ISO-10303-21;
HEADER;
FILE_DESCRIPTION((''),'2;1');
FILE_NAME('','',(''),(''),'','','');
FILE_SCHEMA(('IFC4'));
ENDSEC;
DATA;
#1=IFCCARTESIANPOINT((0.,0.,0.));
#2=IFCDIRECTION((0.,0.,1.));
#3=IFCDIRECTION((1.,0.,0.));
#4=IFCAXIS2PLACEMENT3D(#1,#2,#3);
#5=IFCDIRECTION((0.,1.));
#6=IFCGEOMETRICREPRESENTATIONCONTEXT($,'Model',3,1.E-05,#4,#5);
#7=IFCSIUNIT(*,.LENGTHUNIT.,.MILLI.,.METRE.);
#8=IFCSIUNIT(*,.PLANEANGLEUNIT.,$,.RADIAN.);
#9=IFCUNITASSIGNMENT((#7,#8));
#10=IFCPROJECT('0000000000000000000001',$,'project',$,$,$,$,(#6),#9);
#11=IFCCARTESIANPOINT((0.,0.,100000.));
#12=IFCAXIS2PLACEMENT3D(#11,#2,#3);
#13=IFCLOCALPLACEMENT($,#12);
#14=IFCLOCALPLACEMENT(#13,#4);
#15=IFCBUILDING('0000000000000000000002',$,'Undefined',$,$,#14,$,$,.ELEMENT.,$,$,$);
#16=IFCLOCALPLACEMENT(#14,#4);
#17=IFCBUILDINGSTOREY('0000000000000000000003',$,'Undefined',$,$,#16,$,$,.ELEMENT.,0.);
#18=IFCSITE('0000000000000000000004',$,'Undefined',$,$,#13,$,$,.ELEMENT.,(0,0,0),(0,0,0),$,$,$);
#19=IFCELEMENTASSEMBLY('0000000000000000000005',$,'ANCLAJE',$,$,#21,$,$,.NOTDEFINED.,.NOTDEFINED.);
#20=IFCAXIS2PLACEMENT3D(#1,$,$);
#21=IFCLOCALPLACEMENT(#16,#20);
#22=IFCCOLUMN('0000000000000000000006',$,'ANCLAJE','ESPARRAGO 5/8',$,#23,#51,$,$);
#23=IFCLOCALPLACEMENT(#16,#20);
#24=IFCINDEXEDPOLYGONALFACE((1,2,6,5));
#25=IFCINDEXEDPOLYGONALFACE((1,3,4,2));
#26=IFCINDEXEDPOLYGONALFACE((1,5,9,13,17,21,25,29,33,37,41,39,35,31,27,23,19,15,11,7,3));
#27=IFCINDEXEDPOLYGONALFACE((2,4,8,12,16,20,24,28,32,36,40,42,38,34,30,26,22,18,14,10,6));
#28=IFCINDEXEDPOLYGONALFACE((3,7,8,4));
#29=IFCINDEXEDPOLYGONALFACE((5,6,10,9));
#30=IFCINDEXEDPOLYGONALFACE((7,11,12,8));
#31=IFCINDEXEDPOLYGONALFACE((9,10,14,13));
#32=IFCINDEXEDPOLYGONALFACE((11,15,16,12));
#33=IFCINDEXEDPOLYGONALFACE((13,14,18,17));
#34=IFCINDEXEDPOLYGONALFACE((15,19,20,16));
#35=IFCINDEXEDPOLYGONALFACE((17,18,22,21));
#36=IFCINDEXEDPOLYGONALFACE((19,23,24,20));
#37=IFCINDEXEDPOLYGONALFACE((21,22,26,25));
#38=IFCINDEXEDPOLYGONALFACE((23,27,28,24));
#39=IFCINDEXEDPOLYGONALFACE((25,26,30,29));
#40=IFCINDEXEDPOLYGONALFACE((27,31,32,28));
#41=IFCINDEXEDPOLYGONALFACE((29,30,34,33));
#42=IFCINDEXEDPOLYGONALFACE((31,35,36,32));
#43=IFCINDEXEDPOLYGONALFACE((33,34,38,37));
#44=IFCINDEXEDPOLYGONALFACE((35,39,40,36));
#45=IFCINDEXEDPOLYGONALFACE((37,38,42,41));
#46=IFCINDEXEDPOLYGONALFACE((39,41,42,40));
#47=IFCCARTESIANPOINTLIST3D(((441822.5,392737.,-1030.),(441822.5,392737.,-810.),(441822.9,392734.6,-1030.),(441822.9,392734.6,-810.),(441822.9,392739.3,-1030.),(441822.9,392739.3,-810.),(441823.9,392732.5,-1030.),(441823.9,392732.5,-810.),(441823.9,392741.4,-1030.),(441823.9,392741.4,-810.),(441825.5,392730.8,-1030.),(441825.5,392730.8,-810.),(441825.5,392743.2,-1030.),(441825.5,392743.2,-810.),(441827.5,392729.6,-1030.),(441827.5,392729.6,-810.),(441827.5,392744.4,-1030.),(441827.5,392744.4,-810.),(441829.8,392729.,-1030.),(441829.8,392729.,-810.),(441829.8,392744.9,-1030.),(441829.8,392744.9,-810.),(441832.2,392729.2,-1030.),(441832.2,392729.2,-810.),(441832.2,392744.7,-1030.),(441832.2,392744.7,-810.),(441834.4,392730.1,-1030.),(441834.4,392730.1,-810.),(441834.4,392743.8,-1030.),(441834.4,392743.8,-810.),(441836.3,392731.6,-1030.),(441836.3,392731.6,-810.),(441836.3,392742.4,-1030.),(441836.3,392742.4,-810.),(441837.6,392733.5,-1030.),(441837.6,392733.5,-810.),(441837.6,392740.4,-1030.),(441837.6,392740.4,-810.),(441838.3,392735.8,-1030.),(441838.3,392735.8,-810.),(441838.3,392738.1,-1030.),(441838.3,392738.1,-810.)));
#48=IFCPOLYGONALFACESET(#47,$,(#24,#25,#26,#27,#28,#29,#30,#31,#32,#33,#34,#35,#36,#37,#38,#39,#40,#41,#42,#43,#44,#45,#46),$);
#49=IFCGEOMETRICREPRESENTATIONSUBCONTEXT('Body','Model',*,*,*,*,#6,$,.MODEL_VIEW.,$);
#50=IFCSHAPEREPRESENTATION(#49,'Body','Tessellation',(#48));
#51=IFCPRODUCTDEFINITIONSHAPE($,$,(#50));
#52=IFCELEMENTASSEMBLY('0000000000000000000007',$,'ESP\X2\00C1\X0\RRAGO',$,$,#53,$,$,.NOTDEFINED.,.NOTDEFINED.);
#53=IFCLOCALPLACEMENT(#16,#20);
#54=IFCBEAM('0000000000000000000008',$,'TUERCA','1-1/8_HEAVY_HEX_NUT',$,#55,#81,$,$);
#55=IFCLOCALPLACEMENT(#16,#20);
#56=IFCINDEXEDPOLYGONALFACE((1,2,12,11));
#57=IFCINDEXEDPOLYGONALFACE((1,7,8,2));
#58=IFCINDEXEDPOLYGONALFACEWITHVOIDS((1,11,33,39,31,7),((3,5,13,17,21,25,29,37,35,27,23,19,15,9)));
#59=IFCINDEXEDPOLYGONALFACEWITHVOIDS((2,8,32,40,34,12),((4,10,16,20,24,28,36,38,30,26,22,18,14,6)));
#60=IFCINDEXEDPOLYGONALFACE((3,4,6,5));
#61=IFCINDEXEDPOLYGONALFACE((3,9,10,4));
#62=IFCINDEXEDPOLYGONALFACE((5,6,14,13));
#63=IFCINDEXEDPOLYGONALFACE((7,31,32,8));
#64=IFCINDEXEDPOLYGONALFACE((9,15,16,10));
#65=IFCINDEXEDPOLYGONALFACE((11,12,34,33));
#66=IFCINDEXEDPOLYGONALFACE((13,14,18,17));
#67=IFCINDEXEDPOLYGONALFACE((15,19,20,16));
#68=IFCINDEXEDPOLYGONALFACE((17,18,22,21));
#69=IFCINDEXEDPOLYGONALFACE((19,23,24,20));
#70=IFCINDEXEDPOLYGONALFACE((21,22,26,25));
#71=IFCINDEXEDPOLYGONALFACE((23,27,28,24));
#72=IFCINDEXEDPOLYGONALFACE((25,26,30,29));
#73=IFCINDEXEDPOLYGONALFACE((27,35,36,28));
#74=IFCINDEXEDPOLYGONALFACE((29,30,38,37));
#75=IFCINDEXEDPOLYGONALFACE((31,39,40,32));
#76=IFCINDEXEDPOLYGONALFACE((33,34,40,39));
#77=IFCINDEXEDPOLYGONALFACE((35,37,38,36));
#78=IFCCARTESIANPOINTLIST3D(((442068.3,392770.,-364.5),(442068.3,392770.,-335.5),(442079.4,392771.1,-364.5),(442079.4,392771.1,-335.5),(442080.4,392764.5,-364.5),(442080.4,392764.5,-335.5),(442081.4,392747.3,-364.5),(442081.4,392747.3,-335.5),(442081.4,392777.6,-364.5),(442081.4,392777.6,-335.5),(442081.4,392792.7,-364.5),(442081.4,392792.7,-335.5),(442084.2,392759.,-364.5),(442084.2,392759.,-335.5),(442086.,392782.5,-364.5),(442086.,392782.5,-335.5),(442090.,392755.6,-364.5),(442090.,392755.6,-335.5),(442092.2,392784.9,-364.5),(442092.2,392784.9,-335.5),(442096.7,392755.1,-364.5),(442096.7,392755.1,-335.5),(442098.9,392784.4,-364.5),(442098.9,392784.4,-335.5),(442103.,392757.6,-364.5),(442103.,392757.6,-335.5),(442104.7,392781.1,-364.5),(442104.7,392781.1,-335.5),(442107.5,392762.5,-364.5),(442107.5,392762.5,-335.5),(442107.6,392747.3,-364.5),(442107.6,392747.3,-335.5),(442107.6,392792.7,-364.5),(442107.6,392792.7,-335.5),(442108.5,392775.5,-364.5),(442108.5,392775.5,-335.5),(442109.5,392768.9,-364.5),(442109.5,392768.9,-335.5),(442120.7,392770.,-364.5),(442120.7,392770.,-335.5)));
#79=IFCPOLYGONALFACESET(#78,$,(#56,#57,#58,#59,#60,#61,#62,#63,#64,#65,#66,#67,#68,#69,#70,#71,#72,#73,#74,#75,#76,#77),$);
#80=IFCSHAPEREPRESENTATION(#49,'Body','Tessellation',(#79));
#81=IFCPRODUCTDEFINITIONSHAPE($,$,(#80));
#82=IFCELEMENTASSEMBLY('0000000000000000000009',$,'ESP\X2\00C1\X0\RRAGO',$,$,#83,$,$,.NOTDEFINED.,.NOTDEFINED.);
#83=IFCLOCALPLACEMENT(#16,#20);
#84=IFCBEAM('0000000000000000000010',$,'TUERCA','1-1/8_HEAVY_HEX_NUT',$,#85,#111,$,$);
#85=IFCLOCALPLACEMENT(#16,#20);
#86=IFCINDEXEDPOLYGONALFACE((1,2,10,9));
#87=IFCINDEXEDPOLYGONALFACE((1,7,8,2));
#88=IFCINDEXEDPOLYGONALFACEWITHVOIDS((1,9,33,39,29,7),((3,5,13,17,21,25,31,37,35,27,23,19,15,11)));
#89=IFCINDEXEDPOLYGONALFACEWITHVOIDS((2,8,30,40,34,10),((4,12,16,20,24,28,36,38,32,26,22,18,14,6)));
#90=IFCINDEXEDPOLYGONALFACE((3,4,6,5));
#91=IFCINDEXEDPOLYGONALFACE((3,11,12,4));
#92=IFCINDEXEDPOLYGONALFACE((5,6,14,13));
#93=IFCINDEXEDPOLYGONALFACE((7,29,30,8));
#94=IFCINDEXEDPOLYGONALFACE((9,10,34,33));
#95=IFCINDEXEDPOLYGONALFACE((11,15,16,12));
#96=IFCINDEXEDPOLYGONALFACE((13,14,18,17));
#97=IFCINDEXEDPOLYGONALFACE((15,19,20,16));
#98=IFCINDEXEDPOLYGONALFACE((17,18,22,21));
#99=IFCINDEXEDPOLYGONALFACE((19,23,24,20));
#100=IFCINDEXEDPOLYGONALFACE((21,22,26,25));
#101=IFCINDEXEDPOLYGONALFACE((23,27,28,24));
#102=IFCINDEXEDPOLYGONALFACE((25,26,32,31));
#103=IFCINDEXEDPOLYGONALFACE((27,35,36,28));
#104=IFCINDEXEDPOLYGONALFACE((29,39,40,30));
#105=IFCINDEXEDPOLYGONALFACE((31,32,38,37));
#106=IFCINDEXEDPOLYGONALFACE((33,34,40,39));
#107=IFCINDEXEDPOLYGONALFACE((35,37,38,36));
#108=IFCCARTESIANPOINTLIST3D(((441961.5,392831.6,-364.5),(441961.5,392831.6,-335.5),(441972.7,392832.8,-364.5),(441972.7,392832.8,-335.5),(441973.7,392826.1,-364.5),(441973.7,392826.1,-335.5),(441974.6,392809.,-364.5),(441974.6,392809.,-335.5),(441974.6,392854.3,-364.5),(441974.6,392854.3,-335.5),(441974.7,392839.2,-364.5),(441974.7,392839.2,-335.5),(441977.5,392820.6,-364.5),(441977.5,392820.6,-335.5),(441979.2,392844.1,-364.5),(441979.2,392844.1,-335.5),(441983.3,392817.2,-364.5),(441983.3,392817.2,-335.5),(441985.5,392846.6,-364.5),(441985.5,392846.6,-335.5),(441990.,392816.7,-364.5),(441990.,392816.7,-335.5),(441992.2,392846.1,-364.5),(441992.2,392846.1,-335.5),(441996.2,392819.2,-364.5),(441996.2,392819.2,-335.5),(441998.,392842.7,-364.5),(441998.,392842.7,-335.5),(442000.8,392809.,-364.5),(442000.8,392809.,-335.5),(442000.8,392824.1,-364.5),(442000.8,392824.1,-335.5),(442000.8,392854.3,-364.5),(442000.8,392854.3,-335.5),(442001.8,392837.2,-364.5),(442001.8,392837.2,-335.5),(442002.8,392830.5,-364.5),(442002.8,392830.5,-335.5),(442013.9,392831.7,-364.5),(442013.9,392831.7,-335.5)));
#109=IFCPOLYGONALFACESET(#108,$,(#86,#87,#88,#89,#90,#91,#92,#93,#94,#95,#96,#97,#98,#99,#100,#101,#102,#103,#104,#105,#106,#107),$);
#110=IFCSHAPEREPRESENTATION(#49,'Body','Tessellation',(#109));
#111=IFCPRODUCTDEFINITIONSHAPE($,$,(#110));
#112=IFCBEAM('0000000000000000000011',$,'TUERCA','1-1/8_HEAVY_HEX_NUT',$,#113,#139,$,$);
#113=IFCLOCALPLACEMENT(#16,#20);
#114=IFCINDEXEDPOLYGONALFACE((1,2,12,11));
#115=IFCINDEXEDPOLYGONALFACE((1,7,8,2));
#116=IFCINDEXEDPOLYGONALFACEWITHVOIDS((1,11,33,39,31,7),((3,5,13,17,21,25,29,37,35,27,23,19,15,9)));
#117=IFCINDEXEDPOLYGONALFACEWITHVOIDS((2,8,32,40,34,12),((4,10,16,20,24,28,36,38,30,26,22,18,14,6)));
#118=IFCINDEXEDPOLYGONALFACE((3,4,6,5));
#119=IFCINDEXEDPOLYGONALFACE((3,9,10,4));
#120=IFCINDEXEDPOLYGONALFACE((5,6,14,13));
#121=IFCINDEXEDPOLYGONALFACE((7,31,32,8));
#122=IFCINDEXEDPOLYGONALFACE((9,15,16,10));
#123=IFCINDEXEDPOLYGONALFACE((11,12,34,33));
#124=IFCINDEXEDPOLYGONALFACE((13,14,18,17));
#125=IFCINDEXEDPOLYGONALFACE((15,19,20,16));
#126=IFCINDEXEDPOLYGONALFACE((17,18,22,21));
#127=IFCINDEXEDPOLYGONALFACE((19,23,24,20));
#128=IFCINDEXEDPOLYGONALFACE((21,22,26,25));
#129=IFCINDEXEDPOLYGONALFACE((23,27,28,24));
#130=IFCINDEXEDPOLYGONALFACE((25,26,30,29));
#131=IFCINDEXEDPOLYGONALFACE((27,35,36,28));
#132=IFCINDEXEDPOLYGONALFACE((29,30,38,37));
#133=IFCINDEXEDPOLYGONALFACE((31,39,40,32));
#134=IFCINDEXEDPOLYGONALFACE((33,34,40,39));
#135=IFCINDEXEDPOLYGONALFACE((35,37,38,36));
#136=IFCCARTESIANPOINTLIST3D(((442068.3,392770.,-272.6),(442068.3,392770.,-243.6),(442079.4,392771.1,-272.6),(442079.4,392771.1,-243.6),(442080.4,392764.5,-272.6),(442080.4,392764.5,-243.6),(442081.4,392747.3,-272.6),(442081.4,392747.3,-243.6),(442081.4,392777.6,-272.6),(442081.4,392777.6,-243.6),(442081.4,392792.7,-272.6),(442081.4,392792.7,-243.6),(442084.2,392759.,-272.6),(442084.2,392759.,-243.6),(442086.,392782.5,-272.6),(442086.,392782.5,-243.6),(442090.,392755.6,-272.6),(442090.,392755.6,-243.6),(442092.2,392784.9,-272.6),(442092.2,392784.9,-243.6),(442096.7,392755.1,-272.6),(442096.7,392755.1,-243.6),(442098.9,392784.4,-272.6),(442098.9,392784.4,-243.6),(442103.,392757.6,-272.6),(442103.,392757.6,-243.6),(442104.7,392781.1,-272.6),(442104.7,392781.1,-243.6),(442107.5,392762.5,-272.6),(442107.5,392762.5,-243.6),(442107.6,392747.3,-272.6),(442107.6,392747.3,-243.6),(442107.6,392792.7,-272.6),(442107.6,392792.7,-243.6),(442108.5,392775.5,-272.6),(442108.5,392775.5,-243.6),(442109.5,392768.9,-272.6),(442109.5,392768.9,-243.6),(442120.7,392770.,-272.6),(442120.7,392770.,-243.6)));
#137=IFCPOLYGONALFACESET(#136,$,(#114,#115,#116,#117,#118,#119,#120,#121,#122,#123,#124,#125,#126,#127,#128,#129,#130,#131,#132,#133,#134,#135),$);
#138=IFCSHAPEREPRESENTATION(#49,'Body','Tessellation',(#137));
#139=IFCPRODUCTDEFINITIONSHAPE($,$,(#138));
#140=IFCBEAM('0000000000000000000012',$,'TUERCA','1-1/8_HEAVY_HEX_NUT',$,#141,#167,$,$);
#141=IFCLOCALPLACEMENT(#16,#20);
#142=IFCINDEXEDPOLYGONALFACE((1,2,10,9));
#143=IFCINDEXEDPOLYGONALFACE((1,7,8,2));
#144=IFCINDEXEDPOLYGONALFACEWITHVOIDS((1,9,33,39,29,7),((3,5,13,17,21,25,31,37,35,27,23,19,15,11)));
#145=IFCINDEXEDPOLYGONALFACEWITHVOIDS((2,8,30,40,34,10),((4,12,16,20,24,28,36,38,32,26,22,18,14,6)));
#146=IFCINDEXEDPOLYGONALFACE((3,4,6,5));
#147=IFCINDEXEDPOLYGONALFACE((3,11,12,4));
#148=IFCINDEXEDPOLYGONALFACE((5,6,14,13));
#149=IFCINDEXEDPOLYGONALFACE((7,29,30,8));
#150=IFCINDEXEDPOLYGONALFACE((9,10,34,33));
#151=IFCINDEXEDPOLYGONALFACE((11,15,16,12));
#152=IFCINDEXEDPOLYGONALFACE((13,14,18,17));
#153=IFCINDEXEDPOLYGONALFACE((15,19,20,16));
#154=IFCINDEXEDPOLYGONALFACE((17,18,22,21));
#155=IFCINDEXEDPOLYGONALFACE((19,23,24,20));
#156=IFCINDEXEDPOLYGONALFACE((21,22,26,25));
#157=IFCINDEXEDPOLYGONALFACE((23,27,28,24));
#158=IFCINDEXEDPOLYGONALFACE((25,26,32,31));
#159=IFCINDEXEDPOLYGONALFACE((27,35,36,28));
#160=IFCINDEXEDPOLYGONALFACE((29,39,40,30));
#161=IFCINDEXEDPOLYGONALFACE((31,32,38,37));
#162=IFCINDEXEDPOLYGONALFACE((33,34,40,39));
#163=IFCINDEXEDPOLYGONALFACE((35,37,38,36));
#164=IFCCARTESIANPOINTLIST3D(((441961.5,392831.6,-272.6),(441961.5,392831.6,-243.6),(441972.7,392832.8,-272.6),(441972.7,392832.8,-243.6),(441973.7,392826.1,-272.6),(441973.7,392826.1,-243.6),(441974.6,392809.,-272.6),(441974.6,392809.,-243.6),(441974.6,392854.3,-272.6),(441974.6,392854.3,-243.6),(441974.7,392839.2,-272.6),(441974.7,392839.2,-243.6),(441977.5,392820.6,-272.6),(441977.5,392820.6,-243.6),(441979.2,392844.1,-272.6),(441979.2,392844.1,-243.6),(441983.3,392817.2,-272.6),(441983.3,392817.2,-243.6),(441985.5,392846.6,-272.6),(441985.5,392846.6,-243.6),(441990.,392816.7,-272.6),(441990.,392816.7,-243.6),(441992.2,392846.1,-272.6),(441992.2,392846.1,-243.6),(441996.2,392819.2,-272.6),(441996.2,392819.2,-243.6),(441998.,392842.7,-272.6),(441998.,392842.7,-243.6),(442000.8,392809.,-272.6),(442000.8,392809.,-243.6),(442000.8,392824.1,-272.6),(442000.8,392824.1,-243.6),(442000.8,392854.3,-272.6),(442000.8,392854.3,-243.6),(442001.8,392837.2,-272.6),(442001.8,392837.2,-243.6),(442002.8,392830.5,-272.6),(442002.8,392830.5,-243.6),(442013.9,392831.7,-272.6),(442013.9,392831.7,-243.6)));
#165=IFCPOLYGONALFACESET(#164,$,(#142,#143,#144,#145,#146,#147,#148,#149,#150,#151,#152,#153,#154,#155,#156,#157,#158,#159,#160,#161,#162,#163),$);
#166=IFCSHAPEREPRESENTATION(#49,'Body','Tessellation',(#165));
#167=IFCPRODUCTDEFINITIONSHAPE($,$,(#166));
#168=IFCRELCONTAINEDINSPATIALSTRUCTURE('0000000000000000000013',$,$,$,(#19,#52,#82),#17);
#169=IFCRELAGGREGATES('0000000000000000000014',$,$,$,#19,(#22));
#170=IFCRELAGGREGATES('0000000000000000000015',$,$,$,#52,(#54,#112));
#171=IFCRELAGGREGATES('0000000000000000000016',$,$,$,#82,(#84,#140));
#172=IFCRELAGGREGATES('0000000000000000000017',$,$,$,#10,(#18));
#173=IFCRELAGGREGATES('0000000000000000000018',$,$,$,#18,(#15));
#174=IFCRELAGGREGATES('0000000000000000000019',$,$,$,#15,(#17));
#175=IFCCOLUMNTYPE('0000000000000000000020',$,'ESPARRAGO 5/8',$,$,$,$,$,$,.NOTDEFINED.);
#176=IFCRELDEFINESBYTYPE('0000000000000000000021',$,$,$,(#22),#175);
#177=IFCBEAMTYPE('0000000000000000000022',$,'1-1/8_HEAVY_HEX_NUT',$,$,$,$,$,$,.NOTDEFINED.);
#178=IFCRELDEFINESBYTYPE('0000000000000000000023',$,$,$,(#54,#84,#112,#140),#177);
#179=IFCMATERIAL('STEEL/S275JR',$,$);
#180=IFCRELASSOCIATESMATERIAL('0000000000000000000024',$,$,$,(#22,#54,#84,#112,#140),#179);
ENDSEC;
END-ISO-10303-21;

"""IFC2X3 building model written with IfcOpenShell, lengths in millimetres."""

from ifc_helpers import new_model, si_unit, direction, frame, origin_with_axes, origin_2d_with_axis, place, context, subcontext, project, spatial, polyline, circle, outline, extrude, material, type_object, element, aggregate, save


model = new_model("IFC2X3")

# Units and contexts
model_context = context("Model", 3, precision=1e-05, world=origin_with_axes(), true_north=direction((0.0, 1.0)))
body_context = subcontext(model_context, "Body", "Model", "MODEL_VIEW")
ifc_project = project(units=[si_unit("LENGTHUNIT", "METRE", prefix="MILLI"), si_unit("PLANEANGLEUNIT", "RADIAN")], contexts=[model_context])

# Site, building, storey
site_placement = place(None, frame((0.0, 0.0, 100000.0), z_axis=(0.0, 0.0, 1.0), x_axis=(1.0, 0.0, 0.0)))
site = spatial("IfcSite", under=ifc_project, at=site_placement, Name="Undefined", CompositionType="ELEMENT", RefLatitude=(0, 0, 0), RefLongitude=(0, 0, 0))
building_placement = place(site_placement, origin_with_axes())
building = spatial("IfcBuilding", under=site, at=building_placement, Name="Undefined", CompositionType="ELEMENT")
storey_placement = place(building_placement, origin_with_axes())
storey = spatial("IfcBuildingStorey", under=building, at=storey_placement, Name="Undefined", CompositionType="ELEMENT", Elevation=0.0)

# Element assembly
ifc_material_1 = material(Name="STEEL/S275JR")
assembly_1_placement = place(storey_placement, origin_with_axes())
assembly_1 = element("IfcElementAssembly", 1, at=assembly_1_placement, inside=storey, Name="ANCLAJE", AssemblyPlace="NOTDEFINED", PredefinedType="NOTDEFINED")

# Column
column_type_1 = type_object("IfcColumnType", Name="ESPARRAGO 5/8", PredefinedType="NOTDEFINED")
column_1_placement = place(assembly_1_placement, frame((441830.4, 392737.0, -810.0), z_axis=(0.0, 0.0, -1.0), x_axis=(0.866025, 0.5, 0.0)))
column_1 = element("IfcColumn", 2, at=column_1_placement, type_object=column_type_1, material=ifc_material_1, Name="ANCLAJE", Description="ESPARRAGO 5/8", context=body_context, shape_type="SweptSolid", body=[
    extrude(circle(Radius=7.9, at=origin_2d_with_axis()), frame((0.0, 0.0, 220.0), z_axis=(0.0, 0.0, -1.0), x_axis=(0.0, 1.0, 0.0)), (0.0, 0.0, 1.0), 220.0),
])
aggregate(assembly_1, [column_1])

# Element assemblies, beams
assembly_2_placement = place(storey_placement, origin_with_axes())
assembly_2 = element("IfcElementAssembly", 3, at=assembly_2_placement, inside=storey, Name="ESPÁRRAGO", AssemblyPlace="NOTDEFINED", PredefinedType="NOTDEFINED")
beam_type_1 = type_object("IfcBeamType", Name="1-1/8_HEAVY_HEX_NUT", PredefinedType="NOTDEFINED")
beam_1_placement = place(assembly_2_placement, frame((442094.5, 392770.0, -335.5), z_axis=(0.866025, -0.5, 0.0), x_axis=(0.0, 0.0, -1.0)))
beam_1 = element("IfcBeam", 4, at=beam_1_placement, type_object=beam_type_1, material=ifc_material_1, Name="TUERCA", Description="1-1/8_HEAVY_HEX_NUT", context=body_context, shape_type="SweptSolid", body=[
    extrude(outline(polyline([(-13.1, -22.7), (-26.2, 0.0), (-13.1, 22.7), (13.1, 22.7), (26.2, 0.0), (13.1, -22.7), (-13.1, -22.7)]), holes=[polyline([(6.5, 13.6), (0.0, 15.1), (-6.5, 13.6), (-11.8, 9.4), (-14.7, 3.4), (-14.7, -3.4), (-11.8, -9.4), (-6.5, -13.6), (0.0, -15.1), (6.5, -13.6), (11.8, -9.4), (14.7, -3.4), (14.7, 3.4), (11.8, 9.4), (6.5, 13.6)])]), frame((29.0, 0.0, 0.0), z_axis=(-1.0, 0.0, 0.0), x_axis=(0.0, -1.0, 0.0)), (0.0, 0.0, 1.0), 29.0),
])
assembly_3_placement = place(storey_placement, origin_with_axes())
assembly_3 = element("IfcElementAssembly", 5, at=assembly_3_placement, inside=storey, Name="ESPÁRRAGO", AssemblyPlace="NOTDEFINED", PredefinedType="NOTDEFINED")
beam_2_placement = place(assembly_3_placement, frame((441987.7, 392831.7, -335.5), z_axis=(0.866025, -0.5, 0.0), x_axis=(0.0, 0.0, -1.0)))
beam_2 = element("IfcBeam", 6, at=beam_2_placement, type_object=beam_type_1, material=ifc_material_1, Name="TUERCA", Description="1-1/8_HEAVY_HEX_NUT", context=body_context, shape_type="SweptSolid", body=[
    extrude(outline(polyline([(-13.1, -22.7), (-26.2, 0.0), (-13.1, 22.7), (13.1, 22.7), (26.2, 0.0), (13.1, -22.7), (-13.1, -22.7)]), holes=[polyline([(6.5, 13.6), (0.0, 15.1), (-6.5, 13.6), (-11.8, 9.4), (-14.7, 3.4), (-14.7, -3.4), (-11.8, -9.4), (-6.5, -13.6), (0.0, -15.1), (6.5, -13.6), (11.8, -9.4), (14.7, -3.4), (14.7, 3.4), (11.8, 9.4), (6.5, 13.6)])]), frame((29.0, 0.0, 0.0), z_axis=(-1.0, 0.0, 0.0), x_axis=(0.0, -1.0, 0.0)), (0.0, 0.0, 1.0), 29.0),
])

# Beams
beam_3_placement = place(assembly_2_placement, frame((442094.5, 392770.0, -243.6), z_axis=(0.866025, -0.5, 0.0), x_axis=(0.0, 0.0, -1.0)))
beam_3 = element("IfcBeam", 7, at=beam_3_placement, type_object=beam_type_1, material=ifc_material_1, Name="TUERCA", Description="1-1/8_HEAVY_HEX_NUT", context=body_context, shape_type="SweptSolid", body=[
    extrude(outline(polyline([(-13.1, -22.7), (-26.2, 0.0), (-13.1, 22.7), (13.1, 22.7), (26.2, 0.0), (13.1, -22.7), (-13.1, -22.7)]), holes=[polyline([(6.5, 13.6), (0.0, 15.1), (-6.5, 13.6), (-11.8, 9.4), (-14.7, 3.4), (-14.7, -3.4), (-11.8, -9.4), (-6.5, -13.6), (0.0, -15.1), (6.5, -13.6), (11.8, -9.4), (14.7, -3.4), (14.7, 3.4), (11.8, 9.4), (6.5, 13.6)])]), frame((29.0, 0.0, 0.0), z_axis=(-1.0, 0.0, 0.0), x_axis=(0.0, -1.0, 0.0)), (0.0, 0.0, 1.0), 29.0),
])
beam_4_placement = place(assembly_3_placement, frame((441987.7, 392831.7, -243.6), z_axis=(0.866025, -0.5, 0.0), x_axis=(0.0, 0.0, -1.0)))
beam_4 = element("IfcBeam", 8, at=beam_4_placement, type_object=beam_type_1, material=ifc_material_1, Name="TUERCA", Description="1-1/8_HEAVY_HEX_NUT", context=body_context, shape_type="SweptSolid", body=[
    extrude(outline(polyline([(-13.1, -22.7), (-26.2, 0.0), (-13.1, 22.7), (13.1, 22.7), (26.2, 0.0), (13.1, -22.7), (-13.1, -22.7)]), holes=[polyline([(6.5, 13.6), (0.0, 15.1), (-6.5, 13.6), (-11.8, 9.4), (-14.7, 3.4), (-14.7, -3.4), (-11.8, -9.4), (-6.5, -13.6), (0.0, -15.1), (6.5, -13.6), (11.8, -9.4), (14.7, -3.4), (14.7, 3.4), (11.8, 9.4), (6.5, 13.6)])]), frame((29.0, 0.0, 0.0), z_axis=(-1.0, 0.0, 0.0), x_axis=(0.0, -1.0, 0.0)), (0.0, 0.0, 1.0), 29.0),
])

aggregate(assembly_2, [beam_1, beam_3])
aggregate(assembly_3, [beam_2, beam_4])

save(model, "model.ifc")
